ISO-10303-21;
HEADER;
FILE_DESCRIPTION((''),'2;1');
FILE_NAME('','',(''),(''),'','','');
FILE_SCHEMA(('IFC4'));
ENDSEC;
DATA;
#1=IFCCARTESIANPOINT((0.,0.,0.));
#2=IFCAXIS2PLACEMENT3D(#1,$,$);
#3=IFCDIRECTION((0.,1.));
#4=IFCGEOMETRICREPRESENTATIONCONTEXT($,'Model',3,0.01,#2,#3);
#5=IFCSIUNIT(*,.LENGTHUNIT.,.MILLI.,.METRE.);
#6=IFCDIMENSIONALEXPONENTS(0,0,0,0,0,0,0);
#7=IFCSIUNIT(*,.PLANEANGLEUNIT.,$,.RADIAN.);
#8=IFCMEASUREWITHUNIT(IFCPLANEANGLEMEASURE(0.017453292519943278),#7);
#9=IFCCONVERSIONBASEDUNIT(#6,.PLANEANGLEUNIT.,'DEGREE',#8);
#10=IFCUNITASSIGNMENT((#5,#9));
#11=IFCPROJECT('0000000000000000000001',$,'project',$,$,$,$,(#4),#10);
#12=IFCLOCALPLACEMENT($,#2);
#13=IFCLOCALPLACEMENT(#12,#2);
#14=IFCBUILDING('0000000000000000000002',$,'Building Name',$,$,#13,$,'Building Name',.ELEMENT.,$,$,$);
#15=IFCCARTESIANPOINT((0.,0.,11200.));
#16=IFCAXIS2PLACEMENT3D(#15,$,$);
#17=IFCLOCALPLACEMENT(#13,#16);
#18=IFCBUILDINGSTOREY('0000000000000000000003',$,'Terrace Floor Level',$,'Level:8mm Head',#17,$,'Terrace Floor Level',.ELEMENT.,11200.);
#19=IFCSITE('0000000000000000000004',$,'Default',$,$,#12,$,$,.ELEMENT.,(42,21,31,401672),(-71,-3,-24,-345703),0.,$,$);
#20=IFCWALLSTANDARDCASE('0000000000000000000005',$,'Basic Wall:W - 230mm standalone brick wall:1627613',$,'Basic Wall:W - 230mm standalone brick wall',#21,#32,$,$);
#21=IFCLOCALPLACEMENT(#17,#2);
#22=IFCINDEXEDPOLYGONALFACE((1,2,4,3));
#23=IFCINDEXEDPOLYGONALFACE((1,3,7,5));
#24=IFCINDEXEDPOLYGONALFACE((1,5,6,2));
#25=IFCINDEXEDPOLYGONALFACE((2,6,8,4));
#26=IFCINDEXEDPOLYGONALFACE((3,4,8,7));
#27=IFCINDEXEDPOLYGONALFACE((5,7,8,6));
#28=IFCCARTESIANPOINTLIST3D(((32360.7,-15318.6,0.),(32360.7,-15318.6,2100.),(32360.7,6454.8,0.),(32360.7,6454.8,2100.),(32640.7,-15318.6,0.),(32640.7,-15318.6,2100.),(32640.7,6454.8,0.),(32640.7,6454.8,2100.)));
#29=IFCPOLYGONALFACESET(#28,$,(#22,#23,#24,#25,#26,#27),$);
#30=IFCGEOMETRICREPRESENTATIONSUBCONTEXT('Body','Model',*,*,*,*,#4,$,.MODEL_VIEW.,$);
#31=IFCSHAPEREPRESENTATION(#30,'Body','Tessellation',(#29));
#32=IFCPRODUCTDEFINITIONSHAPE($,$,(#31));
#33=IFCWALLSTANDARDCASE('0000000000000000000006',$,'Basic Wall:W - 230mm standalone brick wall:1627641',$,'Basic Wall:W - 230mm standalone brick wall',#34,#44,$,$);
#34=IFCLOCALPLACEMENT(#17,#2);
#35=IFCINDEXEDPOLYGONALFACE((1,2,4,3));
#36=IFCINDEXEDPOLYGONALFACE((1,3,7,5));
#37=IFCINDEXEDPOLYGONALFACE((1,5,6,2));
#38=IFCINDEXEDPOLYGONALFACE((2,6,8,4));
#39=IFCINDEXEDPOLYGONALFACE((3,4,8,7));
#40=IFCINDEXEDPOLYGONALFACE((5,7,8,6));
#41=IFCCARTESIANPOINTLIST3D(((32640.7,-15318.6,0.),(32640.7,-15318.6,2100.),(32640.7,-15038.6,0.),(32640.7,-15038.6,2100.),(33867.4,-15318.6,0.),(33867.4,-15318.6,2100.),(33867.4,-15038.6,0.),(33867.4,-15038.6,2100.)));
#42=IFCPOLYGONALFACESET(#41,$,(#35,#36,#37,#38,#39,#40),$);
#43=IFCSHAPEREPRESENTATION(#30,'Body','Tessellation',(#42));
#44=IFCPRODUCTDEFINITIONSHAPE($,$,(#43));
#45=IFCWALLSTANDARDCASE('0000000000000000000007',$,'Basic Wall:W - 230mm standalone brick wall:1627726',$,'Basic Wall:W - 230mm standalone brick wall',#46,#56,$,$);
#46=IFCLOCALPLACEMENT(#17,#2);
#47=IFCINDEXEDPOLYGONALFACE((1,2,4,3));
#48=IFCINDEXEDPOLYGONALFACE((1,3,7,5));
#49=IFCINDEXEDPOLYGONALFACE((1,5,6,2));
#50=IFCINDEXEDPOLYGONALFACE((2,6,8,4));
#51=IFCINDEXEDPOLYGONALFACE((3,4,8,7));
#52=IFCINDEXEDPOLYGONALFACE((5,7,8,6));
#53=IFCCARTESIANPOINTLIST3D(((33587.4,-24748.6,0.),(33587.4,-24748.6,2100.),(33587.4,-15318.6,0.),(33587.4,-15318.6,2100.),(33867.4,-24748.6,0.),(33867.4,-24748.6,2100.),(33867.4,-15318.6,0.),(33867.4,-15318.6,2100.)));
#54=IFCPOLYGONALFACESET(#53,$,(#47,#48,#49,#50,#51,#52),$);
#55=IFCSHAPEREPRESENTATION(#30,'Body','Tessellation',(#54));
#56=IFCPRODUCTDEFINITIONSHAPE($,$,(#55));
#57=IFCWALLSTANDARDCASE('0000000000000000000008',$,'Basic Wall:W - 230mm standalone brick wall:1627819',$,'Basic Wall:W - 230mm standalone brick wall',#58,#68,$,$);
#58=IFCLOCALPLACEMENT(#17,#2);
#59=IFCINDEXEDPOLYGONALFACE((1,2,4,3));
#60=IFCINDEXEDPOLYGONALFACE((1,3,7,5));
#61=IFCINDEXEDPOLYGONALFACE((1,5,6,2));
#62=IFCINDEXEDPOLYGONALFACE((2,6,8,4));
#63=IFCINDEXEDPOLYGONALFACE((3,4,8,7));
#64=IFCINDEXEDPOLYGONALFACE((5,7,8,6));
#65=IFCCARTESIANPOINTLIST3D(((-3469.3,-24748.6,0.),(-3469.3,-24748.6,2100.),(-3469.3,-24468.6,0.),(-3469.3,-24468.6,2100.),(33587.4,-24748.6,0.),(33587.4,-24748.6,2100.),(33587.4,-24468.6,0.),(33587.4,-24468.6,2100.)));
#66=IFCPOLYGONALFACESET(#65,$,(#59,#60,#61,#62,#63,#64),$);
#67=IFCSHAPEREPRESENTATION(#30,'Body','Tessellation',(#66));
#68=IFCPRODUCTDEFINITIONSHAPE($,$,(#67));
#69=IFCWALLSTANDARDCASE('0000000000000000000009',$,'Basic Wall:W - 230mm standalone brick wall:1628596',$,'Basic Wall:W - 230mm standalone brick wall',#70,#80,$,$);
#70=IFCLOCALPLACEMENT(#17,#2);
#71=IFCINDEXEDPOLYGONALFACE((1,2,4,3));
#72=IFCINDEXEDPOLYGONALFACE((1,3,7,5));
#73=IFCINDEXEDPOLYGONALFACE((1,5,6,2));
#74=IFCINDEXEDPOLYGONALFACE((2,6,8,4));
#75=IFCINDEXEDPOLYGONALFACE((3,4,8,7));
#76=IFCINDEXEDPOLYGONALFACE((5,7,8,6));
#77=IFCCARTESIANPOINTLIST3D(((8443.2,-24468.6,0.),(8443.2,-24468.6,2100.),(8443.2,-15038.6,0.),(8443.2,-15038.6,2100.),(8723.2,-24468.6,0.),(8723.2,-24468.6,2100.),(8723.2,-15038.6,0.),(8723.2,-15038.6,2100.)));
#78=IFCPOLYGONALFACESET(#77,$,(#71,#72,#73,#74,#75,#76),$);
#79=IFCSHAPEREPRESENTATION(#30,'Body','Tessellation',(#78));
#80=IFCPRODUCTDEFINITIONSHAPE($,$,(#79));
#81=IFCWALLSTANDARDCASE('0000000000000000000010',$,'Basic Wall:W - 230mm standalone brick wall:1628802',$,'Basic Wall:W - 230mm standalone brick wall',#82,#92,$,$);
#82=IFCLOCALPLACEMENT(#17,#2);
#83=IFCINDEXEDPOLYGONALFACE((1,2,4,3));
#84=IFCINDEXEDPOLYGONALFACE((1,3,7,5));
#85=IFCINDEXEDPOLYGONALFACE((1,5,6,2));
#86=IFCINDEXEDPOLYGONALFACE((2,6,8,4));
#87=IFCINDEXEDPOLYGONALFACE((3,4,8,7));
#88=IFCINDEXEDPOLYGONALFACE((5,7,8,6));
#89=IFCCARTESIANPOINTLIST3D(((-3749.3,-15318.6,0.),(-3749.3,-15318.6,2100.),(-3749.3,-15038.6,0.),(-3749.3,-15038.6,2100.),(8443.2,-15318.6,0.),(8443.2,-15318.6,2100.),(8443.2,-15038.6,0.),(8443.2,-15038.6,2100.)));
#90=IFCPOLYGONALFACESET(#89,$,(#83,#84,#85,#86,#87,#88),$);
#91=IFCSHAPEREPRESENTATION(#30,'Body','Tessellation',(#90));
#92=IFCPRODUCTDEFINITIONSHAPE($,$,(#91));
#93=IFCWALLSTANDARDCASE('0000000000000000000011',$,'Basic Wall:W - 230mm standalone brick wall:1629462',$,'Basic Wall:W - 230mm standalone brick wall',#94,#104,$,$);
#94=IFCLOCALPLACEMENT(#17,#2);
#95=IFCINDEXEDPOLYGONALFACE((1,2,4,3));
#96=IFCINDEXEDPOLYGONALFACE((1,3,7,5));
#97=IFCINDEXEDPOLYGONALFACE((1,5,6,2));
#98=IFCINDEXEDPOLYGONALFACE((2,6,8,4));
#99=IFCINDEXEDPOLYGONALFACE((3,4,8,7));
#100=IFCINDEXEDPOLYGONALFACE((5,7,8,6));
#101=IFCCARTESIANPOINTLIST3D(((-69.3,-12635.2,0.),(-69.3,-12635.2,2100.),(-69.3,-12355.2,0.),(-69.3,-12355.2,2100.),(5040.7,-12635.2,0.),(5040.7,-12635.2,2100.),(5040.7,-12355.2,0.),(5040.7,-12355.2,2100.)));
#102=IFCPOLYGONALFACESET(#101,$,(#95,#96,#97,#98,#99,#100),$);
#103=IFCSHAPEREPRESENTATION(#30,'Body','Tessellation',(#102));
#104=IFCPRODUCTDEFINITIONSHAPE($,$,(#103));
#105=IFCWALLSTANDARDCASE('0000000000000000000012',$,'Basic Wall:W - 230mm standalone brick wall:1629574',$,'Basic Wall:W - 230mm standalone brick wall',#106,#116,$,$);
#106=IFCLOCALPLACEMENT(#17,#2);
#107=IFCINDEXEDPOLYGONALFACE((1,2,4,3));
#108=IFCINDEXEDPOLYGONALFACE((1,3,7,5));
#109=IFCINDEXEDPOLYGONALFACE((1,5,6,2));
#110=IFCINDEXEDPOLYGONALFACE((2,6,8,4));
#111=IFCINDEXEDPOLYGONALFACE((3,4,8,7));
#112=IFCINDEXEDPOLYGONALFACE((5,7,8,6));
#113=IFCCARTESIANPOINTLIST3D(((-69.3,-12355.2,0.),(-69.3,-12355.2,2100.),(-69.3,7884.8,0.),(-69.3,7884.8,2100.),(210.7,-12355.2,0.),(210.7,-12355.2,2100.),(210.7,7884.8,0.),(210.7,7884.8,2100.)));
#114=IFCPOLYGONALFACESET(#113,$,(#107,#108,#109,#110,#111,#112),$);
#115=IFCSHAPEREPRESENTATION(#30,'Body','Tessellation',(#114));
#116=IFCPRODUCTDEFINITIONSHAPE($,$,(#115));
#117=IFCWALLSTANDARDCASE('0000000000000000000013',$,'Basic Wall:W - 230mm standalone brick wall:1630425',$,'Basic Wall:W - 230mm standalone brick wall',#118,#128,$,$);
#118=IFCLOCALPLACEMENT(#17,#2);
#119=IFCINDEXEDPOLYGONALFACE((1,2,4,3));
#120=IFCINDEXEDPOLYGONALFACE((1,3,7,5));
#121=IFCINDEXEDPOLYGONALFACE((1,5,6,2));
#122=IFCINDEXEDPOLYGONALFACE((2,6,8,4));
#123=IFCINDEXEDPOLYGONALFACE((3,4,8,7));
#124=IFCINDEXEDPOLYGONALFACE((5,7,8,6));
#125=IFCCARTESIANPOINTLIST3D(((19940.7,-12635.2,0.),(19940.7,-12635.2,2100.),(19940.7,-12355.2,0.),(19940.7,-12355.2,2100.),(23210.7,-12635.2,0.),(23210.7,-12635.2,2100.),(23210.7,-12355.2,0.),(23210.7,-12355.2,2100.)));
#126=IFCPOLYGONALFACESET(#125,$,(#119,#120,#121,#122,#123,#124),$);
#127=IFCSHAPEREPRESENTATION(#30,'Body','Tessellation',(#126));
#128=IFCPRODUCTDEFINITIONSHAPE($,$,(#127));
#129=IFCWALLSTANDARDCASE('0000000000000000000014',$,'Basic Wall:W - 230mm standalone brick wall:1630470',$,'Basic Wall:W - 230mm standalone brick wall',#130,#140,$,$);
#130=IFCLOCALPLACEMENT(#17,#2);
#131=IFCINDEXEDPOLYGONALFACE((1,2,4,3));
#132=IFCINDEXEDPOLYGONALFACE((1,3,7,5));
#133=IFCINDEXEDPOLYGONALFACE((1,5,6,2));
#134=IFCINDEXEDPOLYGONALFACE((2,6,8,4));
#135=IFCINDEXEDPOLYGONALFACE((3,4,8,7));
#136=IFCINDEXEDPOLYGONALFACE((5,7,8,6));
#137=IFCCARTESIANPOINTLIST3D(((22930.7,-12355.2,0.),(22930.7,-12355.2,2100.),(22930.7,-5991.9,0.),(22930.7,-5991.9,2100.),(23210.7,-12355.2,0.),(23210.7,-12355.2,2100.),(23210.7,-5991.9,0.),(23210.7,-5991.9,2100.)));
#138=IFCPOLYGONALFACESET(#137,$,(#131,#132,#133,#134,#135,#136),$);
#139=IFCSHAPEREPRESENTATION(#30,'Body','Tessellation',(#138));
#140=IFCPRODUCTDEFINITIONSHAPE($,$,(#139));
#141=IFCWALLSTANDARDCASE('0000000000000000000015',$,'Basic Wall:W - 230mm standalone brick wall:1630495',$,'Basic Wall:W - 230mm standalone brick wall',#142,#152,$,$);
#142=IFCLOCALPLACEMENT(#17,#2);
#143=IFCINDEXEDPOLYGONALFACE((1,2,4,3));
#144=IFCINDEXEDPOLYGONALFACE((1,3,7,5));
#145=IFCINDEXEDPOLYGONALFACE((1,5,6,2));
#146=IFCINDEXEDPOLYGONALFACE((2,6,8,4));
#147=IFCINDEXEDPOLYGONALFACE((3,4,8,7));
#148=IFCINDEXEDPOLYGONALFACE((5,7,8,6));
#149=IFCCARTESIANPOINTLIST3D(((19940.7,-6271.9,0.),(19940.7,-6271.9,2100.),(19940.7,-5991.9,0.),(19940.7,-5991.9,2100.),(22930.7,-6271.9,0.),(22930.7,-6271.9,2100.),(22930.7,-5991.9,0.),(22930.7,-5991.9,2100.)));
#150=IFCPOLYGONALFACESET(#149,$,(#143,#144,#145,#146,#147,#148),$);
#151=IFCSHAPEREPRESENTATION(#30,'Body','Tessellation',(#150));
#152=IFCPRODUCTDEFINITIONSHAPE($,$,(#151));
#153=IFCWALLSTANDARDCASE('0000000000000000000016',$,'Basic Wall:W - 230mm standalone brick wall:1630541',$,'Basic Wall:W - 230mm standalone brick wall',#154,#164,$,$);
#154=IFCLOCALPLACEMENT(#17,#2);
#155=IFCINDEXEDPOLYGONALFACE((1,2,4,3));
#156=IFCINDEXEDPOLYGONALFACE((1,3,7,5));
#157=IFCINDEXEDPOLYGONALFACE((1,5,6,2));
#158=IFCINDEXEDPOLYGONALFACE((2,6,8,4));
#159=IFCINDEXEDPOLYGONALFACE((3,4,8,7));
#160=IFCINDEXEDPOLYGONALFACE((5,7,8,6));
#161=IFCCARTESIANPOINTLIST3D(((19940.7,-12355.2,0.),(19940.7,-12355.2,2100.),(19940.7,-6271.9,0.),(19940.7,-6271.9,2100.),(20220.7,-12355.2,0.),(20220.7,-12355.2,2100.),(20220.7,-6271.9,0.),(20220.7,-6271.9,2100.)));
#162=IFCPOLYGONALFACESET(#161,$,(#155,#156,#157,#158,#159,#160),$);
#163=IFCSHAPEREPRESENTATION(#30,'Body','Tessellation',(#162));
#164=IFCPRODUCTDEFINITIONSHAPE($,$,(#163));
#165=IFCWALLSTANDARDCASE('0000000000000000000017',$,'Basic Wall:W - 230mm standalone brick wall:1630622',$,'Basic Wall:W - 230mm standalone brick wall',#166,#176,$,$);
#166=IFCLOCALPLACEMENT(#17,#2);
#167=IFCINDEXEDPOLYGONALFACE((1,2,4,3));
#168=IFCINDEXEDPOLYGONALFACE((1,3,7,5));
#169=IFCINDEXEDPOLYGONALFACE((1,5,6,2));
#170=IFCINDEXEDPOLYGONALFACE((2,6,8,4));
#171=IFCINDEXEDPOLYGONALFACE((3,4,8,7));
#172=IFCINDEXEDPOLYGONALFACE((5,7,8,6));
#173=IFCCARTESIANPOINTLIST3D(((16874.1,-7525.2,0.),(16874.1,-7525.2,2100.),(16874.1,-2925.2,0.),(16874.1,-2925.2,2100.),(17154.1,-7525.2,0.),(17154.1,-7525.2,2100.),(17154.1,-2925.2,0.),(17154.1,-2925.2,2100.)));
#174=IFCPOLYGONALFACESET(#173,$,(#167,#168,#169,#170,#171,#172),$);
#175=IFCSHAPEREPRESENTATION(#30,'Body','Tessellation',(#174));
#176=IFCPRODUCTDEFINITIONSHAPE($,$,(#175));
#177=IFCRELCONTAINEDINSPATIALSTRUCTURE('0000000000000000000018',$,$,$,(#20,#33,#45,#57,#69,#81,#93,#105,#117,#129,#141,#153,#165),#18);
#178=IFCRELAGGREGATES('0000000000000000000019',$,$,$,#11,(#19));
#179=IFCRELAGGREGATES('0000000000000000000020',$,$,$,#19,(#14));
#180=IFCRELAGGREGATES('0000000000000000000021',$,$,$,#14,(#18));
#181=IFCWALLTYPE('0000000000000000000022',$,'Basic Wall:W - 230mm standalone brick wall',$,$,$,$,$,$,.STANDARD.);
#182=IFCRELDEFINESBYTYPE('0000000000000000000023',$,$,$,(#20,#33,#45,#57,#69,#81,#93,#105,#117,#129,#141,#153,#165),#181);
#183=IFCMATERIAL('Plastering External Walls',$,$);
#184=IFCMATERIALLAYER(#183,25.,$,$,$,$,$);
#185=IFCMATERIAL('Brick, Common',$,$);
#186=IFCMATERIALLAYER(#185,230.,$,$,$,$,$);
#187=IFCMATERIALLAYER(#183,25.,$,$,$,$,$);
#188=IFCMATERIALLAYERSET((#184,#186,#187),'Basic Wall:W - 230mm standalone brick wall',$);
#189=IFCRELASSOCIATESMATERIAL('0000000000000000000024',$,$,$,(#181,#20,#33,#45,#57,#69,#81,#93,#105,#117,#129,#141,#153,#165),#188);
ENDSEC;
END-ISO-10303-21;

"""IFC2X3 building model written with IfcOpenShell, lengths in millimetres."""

from ifc_helpers import new_model, entity, si_unit, converted_unit, direction, frame, frame_2d, origin, place, context, subcontext, project, spatial, rectangle, extrude, material, layer, layer_set, layer_usage, type_object, element, save


model = new_model("IFC2X3")

# Units and contexts
model_context = context("Model", 3, precision=0.01, world=origin(), true_north=direction((0.0, 1.0)))
body_context = subcontext(model_context, "Body", "Model", "MODEL_VIEW")
ifc_project = project(units=[si_unit("LENGTHUNIT", "METRE", prefix="MILLI"), converted_unit("PLANEANGLEUNIT", "DEGREE", entity("IfcPlaneAngleMeasure", 0.017453292519943278), si_unit("PLANEANGLEUNIT", "RADIAN"), dimensions=[0, 0, 0, 0, 0, 0, 0])], contexts=[model_context])

# Site, building, storey
site_placement = place(None, origin())
site = spatial("IfcSite", under=ifc_project, at=site_placement, Name="Default", CompositionType="ELEMENT", RefLatitude=(42, 21, 31, 401672), RefLongitude=(-71, -3, -24, -345703), RefElevation=0.0)
building_placement = place(site_placement, origin())
building = spatial("IfcBuilding", under=site, at=building_placement, Name="Building Name", LongName="Building Name", CompositionType="ELEMENT")
storey_placement = place(building_placement, frame((0.0, 0.0, 11200.0)))
storey = spatial("IfcBuildingStorey", under=building, at=storey_placement, Name="Terrace Floor Level", ObjectType="Level:8mm Head", LongName="Terrace Floor Level", CompositionType="ELEMENT", Elevation=11200.0)

# Walls
ifc_material_1 = material(Name="Plastering External Walls")
ifc_layer_1 = layer(ifc_material_1, 25.0)
ifc_material_2 = material(Name="Brick, Common")
ifc_layer_2 = layer(ifc_material_2, 230.0)
ifc_layer_3 = layer(ifc_material_1, 25.0)
ifc_layer_set = layer_set([ifc_layer_1, ifc_layer_2, ifc_layer_3], Name="Basic Wall:W - 230mm standalone brick wall")
ifc_layer_usage_1 = layer_usage(ifc_layer_set, "AXIS2", "NEGATIVE", 140.0)
wall_type = type_object("IfcWallType", Name="Basic Wall:W - 230mm standalone brick wall", PredefinedType="STANDARD", material=ifc_layer_set)
wall_1_placement = place(storey_placement, frame((32500.7, 6454.8, 0.0), z_axis=(0.0, 0.0, 1.0), x_axis=(0.0, -1.0, 0.0)))
element("IfcWallStandardCase", 1, at=wall_1_placement, inside=storey, type_object=wall_type, material=ifc_layer_usage_1, Name="Basic Wall:W - 230mm standalone brick wall:1627613", ObjectType="Basic Wall:W - 230mm standalone brick wall", context=body_context, shape_type="SweptSolid", body=[
    extrude(rectangle(XDim=21773.3, YDim=280.0, at=frame_2d((10886.7, 0.0), x_axis=(-1.0, 0.0))), origin(), (0.0, 0.0, 1.0), 2100.0),
])
ifc_layer_usage_2 = layer_usage(ifc_layer_set, "AXIS2", "NEGATIVE", 140.0)
wall_2_placement = place(storey_placement, frame((32640.7, -15178.6, 0.0)))
element("IfcWallStandardCase", 2, at=wall_2_placement, inside=storey, type_object=wall_type, material=ifc_layer_usage_2, Name="Basic Wall:W - 230mm standalone brick wall:1627641", ObjectType="Basic Wall:W - 230mm standalone brick wall", context=body_context, shape_type="SweptSolid", body=[
    extrude(rectangle(XDim=1226.7, YDim=280.0, at=frame_2d((613.3, 0.0), x_axis=(-1.0, 0.0))), origin(), (0.0, 0.0, 1.0), 2100.0),
])
ifc_layer_usage_3 = layer_usage(ifc_layer_set, "AXIS2", "NEGATIVE", 140.0)
wall_3_placement = place(storey_placement, frame((33727.4, -15318.6, 0.0), z_axis=(0.0, 0.0, 1.0), x_axis=(0.0, -1.0, 0.0)))
element("IfcWallStandardCase", 3, at=wall_3_placement, inside=storey, type_object=wall_type, material=ifc_layer_usage_3, Name="Basic Wall:W - 230mm standalone brick wall:1627726", ObjectType="Basic Wall:W - 230mm standalone brick wall", context=body_context, shape_type="SweptSolid", body=[
    extrude(rectangle(XDim=9430.0, YDim=280.0, at=frame_2d((4715.0, 0.0), x_axis=(-1.0, 0.0))), origin(), (0.0, 0.0, 1.0), 2100.0),
])
ifc_layer_usage_4 = layer_usage(ifc_layer_set, "AXIS2", "NEGATIVE", 140.0)
wall_4_placement = place(storey_placement, frame((33587.4, -24608.6, 0.0), z_axis=(0.0, 0.0, 1.0), x_axis=(-1.0, 0.0, 0.0)))
element("IfcWallStandardCase", 4, at=wall_4_placement, inside=storey, type_object=wall_type, material=ifc_layer_usage_4, Name="Basic Wall:W - 230mm standalone brick wall:1627819", ObjectType="Basic Wall:W - 230mm standalone brick wall", context=body_context, shape_type="SweptSolid", body=[
    extrude(rectangle(XDim=37056.7, YDim=280.0, at=frame_2d((18528.3, 0.0), x_axis=(-1.0, 0.0))), origin(), (0.0, 0.0, 1.0), 2100.0),
])
ifc_layer_usage_5 = layer_usage(ifc_layer_set, "AXIS2", "NEGATIVE", 140.0)
wall_5_placement = place(storey_placement, frame((8583.2, -24468.6, 0.0), z_axis=(0.0, 0.0, 1.0), x_axis=(0.0, 1.0, 0.0)))
element("IfcWallStandardCase", 5, at=wall_5_placement, inside=storey, type_object=wall_type, material=ifc_layer_usage_5, Name="Basic Wall:W - 230mm standalone brick wall:1628596", ObjectType="Basic Wall:W - 230mm standalone brick wall", context=body_context, shape_type="SweptSolid", body=[
    extrude(rectangle(XDim=9430.0, YDim=280.0, at=frame_2d((4715.0, 0.0), x_axis=(-1.0, 0.0))), origin(), (0.0, 0.0, 1.0), 2100.0),
])
ifc_layer_usage_6 = layer_usage(ifc_layer_set, "AXIS2", "NEGATIVE", 140.0)
wall_6_placement = place(storey_placement, frame((8443.2, -15178.6, 0.0), z_axis=(0.0, 0.0, 1.0), x_axis=(-1.0, 0.0, 0.0)))
element("IfcWallStandardCase", 6, at=wall_6_placement, inside=storey, type_object=wall_type, material=ifc_layer_usage_6, Name="Basic Wall:W - 230mm standalone brick wall:1628802", ObjectType="Basic Wall:W - 230mm standalone brick wall", context=body_context, shape_type="SweptSolid", body=[
    extrude(rectangle(XDim=12192.5, YDim=280.0, at=frame_2d((6096.2, 0.0), x_axis=(-1.0, 0.0))), origin(), (0.0, 0.0, 1.0), 2100.0),
])
ifc_layer_usage_7 = layer_usage(ifc_layer_set, "AXIS2", "NEGATIVE", 140.0)
wall_7_placement = place(storey_placement, frame((5040.7, -12495.2, 0.0), z_axis=(0.0, 0.0, 1.0), x_axis=(-1.0, 0.0, 0.0)))
element("IfcWallStandardCase", 7, at=wall_7_placement, inside=storey, type_object=wall_type, material=ifc_layer_usage_7, Name="Basic Wall:W - 230mm standalone brick wall:1629462", ObjectType="Basic Wall:W - 230mm standalone brick wall", context=body_context, shape_type="SweptSolid", body=[
    extrude(rectangle(XDim=5110.0, YDim=280.0, at=frame_2d((2555.0, 0.0), x_axis=(-1.0, 0.0))), origin(), (0.0, 0.0, 1.0), 2100.0),
])
ifc_layer_usage_8 = layer_usage(ifc_layer_set, "AXIS2", "NEGATIVE", 140.0)
wall_8_placement = place(storey_placement, frame((70.7, -12355.2, 0.0), z_axis=(0.0, 0.0, 1.0), x_axis=(0.0, 1.0, 0.0)))
element("IfcWallStandardCase", 8, at=wall_8_placement, inside=storey, type_object=wall_type, material=ifc_layer_usage_8, Name="Basic Wall:W - 230mm standalone brick wall:1629574", ObjectType="Basic Wall:W - 230mm standalone brick wall", context=body_context, shape_type="SweptSolid", body=[
    extrude(rectangle(XDim=20240.0, YDim=280.0, at=frame_2d((10120.0, 0.0), x_axis=(-1.0, 0.0))), origin(), (0.0, 0.0, 1.0), 2100.0),
])
ifc_layer_usage_9 = layer_usage(ifc_layer_set, "AXIS2", "NEGATIVE", 140.0)
wall_9_placement = place(storey_placement, frame((19940.7, -12495.2, 0.0)))
element("IfcWallStandardCase", 9, at=wall_9_placement, inside=storey, type_object=wall_type, material=ifc_layer_usage_9, Name="Basic Wall:W - 230mm standalone brick wall:1630425", ObjectType="Basic Wall:W - 230mm standalone brick wall", context=body_context, shape_type="SweptSolid", body=[
    extrude(rectangle(XDim=3270.0, YDim=280.0, at=frame_2d((1635.0, 0.0), x_axis=(-1.0, 0.0))), origin(), (0.0, 0.0, 1.0), 2100.0),
])
ifc_layer_usage_10 = layer_usage(ifc_layer_set, "AXIS2", "NEGATIVE", 140.0)
wall_10_placement = place(storey_placement, frame((23070.7, -12355.2, 0.0), z_axis=(0.0, 0.0, 1.0), x_axis=(0.0, 1.0, 0.0)))
element("IfcWallStandardCase", 10, at=wall_10_placement, inside=storey, type_object=wall_type, material=ifc_layer_usage_10, Name="Basic Wall:W - 230mm standalone brick wall:1630470", ObjectType="Basic Wall:W - 230mm standalone brick wall", context=body_context, shape_type="SweptSolid", body=[
    extrude(rectangle(XDim=6363.3, YDim=280.0, at=frame_2d((3181.7, 0.0), x_axis=(-1.0, 0.0))), origin(), (0.0, 0.0, 1.0), 2100.0),
])
ifc_layer_usage_11 = layer_usage(ifc_layer_set, "AXIS2", "NEGATIVE", 140.0)
wall_11_placement = place(storey_placement, frame((22930.7, -6131.9, 0.0), z_axis=(0.0, 0.0, 1.0), x_axis=(-1.0, 0.0, 0.0)))
element("IfcWallStandardCase", 11, at=wall_11_placement, inside=storey, type_object=wall_type, material=ifc_layer_usage_11, Name="Basic Wall:W - 230mm standalone brick wall:1630495", ObjectType="Basic Wall:W - 230mm standalone brick wall", context=body_context, shape_type="SweptSolid", body=[
    extrude(rectangle(XDim=2990.0, YDim=280.0, at=frame_2d((1495.0, 0.0), x_axis=(-1.0, 0.0))), origin(), (0.0, 0.0, 1.0), 2100.0),
])
ifc_layer_usage_12 = layer_usage(ifc_layer_set, "AXIS2", "NEGATIVE", 140.0)
wall_12_placement = place(storey_placement, frame((20080.7, -6271.9, 0.0), z_axis=(0.0, 0.0, 1.0), x_axis=(0.0, -1.0, 0.0)))
element("IfcWallStandardCase", 12, at=wall_12_placement, inside=storey, type_object=wall_type, material=ifc_layer_usage_12, Name="Basic Wall:W - 230mm standalone brick wall:1630541", ObjectType="Basic Wall:W - 230mm standalone brick wall", context=body_context, shape_type="SweptSolid", body=[
    extrude(rectangle(XDim=6083.3, YDim=280.0, at=frame_2d((3041.7, 0.0), x_axis=(-1.0, 0.0))), origin(), (0.0, 0.0, 1.0), 2100.0),
])
ifc_layer_usage_13 = layer_usage(ifc_layer_set, "AXIS2", "NEGATIVE", 140.0)
wall_13_placement = place(storey_placement, frame((17014.1, -7525.2, 0.0), z_axis=(0.0, 0.0, 1.0), x_axis=(0.0, 1.0, 0.0)))
element("IfcWallStandardCase", 13, at=wall_13_placement, inside=storey, type_object=wall_type, material=ifc_layer_usage_13, Name="Basic Wall:W - 230mm standalone brick wall:1630622", ObjectType="Basic Wall:W - 230mm standalone brick wall", context=body_context, shape_type="SweptSolid", body=[
    extrude(rectangle(XDim=4600.0, YDim=280.0, at=frame_2d((2300.0, 0.0), x_axis=(-1.0, 0.0))), origin(), (0.0, 0.0, 1.0), 2100.0),
])

save(model, "model.ifc")
